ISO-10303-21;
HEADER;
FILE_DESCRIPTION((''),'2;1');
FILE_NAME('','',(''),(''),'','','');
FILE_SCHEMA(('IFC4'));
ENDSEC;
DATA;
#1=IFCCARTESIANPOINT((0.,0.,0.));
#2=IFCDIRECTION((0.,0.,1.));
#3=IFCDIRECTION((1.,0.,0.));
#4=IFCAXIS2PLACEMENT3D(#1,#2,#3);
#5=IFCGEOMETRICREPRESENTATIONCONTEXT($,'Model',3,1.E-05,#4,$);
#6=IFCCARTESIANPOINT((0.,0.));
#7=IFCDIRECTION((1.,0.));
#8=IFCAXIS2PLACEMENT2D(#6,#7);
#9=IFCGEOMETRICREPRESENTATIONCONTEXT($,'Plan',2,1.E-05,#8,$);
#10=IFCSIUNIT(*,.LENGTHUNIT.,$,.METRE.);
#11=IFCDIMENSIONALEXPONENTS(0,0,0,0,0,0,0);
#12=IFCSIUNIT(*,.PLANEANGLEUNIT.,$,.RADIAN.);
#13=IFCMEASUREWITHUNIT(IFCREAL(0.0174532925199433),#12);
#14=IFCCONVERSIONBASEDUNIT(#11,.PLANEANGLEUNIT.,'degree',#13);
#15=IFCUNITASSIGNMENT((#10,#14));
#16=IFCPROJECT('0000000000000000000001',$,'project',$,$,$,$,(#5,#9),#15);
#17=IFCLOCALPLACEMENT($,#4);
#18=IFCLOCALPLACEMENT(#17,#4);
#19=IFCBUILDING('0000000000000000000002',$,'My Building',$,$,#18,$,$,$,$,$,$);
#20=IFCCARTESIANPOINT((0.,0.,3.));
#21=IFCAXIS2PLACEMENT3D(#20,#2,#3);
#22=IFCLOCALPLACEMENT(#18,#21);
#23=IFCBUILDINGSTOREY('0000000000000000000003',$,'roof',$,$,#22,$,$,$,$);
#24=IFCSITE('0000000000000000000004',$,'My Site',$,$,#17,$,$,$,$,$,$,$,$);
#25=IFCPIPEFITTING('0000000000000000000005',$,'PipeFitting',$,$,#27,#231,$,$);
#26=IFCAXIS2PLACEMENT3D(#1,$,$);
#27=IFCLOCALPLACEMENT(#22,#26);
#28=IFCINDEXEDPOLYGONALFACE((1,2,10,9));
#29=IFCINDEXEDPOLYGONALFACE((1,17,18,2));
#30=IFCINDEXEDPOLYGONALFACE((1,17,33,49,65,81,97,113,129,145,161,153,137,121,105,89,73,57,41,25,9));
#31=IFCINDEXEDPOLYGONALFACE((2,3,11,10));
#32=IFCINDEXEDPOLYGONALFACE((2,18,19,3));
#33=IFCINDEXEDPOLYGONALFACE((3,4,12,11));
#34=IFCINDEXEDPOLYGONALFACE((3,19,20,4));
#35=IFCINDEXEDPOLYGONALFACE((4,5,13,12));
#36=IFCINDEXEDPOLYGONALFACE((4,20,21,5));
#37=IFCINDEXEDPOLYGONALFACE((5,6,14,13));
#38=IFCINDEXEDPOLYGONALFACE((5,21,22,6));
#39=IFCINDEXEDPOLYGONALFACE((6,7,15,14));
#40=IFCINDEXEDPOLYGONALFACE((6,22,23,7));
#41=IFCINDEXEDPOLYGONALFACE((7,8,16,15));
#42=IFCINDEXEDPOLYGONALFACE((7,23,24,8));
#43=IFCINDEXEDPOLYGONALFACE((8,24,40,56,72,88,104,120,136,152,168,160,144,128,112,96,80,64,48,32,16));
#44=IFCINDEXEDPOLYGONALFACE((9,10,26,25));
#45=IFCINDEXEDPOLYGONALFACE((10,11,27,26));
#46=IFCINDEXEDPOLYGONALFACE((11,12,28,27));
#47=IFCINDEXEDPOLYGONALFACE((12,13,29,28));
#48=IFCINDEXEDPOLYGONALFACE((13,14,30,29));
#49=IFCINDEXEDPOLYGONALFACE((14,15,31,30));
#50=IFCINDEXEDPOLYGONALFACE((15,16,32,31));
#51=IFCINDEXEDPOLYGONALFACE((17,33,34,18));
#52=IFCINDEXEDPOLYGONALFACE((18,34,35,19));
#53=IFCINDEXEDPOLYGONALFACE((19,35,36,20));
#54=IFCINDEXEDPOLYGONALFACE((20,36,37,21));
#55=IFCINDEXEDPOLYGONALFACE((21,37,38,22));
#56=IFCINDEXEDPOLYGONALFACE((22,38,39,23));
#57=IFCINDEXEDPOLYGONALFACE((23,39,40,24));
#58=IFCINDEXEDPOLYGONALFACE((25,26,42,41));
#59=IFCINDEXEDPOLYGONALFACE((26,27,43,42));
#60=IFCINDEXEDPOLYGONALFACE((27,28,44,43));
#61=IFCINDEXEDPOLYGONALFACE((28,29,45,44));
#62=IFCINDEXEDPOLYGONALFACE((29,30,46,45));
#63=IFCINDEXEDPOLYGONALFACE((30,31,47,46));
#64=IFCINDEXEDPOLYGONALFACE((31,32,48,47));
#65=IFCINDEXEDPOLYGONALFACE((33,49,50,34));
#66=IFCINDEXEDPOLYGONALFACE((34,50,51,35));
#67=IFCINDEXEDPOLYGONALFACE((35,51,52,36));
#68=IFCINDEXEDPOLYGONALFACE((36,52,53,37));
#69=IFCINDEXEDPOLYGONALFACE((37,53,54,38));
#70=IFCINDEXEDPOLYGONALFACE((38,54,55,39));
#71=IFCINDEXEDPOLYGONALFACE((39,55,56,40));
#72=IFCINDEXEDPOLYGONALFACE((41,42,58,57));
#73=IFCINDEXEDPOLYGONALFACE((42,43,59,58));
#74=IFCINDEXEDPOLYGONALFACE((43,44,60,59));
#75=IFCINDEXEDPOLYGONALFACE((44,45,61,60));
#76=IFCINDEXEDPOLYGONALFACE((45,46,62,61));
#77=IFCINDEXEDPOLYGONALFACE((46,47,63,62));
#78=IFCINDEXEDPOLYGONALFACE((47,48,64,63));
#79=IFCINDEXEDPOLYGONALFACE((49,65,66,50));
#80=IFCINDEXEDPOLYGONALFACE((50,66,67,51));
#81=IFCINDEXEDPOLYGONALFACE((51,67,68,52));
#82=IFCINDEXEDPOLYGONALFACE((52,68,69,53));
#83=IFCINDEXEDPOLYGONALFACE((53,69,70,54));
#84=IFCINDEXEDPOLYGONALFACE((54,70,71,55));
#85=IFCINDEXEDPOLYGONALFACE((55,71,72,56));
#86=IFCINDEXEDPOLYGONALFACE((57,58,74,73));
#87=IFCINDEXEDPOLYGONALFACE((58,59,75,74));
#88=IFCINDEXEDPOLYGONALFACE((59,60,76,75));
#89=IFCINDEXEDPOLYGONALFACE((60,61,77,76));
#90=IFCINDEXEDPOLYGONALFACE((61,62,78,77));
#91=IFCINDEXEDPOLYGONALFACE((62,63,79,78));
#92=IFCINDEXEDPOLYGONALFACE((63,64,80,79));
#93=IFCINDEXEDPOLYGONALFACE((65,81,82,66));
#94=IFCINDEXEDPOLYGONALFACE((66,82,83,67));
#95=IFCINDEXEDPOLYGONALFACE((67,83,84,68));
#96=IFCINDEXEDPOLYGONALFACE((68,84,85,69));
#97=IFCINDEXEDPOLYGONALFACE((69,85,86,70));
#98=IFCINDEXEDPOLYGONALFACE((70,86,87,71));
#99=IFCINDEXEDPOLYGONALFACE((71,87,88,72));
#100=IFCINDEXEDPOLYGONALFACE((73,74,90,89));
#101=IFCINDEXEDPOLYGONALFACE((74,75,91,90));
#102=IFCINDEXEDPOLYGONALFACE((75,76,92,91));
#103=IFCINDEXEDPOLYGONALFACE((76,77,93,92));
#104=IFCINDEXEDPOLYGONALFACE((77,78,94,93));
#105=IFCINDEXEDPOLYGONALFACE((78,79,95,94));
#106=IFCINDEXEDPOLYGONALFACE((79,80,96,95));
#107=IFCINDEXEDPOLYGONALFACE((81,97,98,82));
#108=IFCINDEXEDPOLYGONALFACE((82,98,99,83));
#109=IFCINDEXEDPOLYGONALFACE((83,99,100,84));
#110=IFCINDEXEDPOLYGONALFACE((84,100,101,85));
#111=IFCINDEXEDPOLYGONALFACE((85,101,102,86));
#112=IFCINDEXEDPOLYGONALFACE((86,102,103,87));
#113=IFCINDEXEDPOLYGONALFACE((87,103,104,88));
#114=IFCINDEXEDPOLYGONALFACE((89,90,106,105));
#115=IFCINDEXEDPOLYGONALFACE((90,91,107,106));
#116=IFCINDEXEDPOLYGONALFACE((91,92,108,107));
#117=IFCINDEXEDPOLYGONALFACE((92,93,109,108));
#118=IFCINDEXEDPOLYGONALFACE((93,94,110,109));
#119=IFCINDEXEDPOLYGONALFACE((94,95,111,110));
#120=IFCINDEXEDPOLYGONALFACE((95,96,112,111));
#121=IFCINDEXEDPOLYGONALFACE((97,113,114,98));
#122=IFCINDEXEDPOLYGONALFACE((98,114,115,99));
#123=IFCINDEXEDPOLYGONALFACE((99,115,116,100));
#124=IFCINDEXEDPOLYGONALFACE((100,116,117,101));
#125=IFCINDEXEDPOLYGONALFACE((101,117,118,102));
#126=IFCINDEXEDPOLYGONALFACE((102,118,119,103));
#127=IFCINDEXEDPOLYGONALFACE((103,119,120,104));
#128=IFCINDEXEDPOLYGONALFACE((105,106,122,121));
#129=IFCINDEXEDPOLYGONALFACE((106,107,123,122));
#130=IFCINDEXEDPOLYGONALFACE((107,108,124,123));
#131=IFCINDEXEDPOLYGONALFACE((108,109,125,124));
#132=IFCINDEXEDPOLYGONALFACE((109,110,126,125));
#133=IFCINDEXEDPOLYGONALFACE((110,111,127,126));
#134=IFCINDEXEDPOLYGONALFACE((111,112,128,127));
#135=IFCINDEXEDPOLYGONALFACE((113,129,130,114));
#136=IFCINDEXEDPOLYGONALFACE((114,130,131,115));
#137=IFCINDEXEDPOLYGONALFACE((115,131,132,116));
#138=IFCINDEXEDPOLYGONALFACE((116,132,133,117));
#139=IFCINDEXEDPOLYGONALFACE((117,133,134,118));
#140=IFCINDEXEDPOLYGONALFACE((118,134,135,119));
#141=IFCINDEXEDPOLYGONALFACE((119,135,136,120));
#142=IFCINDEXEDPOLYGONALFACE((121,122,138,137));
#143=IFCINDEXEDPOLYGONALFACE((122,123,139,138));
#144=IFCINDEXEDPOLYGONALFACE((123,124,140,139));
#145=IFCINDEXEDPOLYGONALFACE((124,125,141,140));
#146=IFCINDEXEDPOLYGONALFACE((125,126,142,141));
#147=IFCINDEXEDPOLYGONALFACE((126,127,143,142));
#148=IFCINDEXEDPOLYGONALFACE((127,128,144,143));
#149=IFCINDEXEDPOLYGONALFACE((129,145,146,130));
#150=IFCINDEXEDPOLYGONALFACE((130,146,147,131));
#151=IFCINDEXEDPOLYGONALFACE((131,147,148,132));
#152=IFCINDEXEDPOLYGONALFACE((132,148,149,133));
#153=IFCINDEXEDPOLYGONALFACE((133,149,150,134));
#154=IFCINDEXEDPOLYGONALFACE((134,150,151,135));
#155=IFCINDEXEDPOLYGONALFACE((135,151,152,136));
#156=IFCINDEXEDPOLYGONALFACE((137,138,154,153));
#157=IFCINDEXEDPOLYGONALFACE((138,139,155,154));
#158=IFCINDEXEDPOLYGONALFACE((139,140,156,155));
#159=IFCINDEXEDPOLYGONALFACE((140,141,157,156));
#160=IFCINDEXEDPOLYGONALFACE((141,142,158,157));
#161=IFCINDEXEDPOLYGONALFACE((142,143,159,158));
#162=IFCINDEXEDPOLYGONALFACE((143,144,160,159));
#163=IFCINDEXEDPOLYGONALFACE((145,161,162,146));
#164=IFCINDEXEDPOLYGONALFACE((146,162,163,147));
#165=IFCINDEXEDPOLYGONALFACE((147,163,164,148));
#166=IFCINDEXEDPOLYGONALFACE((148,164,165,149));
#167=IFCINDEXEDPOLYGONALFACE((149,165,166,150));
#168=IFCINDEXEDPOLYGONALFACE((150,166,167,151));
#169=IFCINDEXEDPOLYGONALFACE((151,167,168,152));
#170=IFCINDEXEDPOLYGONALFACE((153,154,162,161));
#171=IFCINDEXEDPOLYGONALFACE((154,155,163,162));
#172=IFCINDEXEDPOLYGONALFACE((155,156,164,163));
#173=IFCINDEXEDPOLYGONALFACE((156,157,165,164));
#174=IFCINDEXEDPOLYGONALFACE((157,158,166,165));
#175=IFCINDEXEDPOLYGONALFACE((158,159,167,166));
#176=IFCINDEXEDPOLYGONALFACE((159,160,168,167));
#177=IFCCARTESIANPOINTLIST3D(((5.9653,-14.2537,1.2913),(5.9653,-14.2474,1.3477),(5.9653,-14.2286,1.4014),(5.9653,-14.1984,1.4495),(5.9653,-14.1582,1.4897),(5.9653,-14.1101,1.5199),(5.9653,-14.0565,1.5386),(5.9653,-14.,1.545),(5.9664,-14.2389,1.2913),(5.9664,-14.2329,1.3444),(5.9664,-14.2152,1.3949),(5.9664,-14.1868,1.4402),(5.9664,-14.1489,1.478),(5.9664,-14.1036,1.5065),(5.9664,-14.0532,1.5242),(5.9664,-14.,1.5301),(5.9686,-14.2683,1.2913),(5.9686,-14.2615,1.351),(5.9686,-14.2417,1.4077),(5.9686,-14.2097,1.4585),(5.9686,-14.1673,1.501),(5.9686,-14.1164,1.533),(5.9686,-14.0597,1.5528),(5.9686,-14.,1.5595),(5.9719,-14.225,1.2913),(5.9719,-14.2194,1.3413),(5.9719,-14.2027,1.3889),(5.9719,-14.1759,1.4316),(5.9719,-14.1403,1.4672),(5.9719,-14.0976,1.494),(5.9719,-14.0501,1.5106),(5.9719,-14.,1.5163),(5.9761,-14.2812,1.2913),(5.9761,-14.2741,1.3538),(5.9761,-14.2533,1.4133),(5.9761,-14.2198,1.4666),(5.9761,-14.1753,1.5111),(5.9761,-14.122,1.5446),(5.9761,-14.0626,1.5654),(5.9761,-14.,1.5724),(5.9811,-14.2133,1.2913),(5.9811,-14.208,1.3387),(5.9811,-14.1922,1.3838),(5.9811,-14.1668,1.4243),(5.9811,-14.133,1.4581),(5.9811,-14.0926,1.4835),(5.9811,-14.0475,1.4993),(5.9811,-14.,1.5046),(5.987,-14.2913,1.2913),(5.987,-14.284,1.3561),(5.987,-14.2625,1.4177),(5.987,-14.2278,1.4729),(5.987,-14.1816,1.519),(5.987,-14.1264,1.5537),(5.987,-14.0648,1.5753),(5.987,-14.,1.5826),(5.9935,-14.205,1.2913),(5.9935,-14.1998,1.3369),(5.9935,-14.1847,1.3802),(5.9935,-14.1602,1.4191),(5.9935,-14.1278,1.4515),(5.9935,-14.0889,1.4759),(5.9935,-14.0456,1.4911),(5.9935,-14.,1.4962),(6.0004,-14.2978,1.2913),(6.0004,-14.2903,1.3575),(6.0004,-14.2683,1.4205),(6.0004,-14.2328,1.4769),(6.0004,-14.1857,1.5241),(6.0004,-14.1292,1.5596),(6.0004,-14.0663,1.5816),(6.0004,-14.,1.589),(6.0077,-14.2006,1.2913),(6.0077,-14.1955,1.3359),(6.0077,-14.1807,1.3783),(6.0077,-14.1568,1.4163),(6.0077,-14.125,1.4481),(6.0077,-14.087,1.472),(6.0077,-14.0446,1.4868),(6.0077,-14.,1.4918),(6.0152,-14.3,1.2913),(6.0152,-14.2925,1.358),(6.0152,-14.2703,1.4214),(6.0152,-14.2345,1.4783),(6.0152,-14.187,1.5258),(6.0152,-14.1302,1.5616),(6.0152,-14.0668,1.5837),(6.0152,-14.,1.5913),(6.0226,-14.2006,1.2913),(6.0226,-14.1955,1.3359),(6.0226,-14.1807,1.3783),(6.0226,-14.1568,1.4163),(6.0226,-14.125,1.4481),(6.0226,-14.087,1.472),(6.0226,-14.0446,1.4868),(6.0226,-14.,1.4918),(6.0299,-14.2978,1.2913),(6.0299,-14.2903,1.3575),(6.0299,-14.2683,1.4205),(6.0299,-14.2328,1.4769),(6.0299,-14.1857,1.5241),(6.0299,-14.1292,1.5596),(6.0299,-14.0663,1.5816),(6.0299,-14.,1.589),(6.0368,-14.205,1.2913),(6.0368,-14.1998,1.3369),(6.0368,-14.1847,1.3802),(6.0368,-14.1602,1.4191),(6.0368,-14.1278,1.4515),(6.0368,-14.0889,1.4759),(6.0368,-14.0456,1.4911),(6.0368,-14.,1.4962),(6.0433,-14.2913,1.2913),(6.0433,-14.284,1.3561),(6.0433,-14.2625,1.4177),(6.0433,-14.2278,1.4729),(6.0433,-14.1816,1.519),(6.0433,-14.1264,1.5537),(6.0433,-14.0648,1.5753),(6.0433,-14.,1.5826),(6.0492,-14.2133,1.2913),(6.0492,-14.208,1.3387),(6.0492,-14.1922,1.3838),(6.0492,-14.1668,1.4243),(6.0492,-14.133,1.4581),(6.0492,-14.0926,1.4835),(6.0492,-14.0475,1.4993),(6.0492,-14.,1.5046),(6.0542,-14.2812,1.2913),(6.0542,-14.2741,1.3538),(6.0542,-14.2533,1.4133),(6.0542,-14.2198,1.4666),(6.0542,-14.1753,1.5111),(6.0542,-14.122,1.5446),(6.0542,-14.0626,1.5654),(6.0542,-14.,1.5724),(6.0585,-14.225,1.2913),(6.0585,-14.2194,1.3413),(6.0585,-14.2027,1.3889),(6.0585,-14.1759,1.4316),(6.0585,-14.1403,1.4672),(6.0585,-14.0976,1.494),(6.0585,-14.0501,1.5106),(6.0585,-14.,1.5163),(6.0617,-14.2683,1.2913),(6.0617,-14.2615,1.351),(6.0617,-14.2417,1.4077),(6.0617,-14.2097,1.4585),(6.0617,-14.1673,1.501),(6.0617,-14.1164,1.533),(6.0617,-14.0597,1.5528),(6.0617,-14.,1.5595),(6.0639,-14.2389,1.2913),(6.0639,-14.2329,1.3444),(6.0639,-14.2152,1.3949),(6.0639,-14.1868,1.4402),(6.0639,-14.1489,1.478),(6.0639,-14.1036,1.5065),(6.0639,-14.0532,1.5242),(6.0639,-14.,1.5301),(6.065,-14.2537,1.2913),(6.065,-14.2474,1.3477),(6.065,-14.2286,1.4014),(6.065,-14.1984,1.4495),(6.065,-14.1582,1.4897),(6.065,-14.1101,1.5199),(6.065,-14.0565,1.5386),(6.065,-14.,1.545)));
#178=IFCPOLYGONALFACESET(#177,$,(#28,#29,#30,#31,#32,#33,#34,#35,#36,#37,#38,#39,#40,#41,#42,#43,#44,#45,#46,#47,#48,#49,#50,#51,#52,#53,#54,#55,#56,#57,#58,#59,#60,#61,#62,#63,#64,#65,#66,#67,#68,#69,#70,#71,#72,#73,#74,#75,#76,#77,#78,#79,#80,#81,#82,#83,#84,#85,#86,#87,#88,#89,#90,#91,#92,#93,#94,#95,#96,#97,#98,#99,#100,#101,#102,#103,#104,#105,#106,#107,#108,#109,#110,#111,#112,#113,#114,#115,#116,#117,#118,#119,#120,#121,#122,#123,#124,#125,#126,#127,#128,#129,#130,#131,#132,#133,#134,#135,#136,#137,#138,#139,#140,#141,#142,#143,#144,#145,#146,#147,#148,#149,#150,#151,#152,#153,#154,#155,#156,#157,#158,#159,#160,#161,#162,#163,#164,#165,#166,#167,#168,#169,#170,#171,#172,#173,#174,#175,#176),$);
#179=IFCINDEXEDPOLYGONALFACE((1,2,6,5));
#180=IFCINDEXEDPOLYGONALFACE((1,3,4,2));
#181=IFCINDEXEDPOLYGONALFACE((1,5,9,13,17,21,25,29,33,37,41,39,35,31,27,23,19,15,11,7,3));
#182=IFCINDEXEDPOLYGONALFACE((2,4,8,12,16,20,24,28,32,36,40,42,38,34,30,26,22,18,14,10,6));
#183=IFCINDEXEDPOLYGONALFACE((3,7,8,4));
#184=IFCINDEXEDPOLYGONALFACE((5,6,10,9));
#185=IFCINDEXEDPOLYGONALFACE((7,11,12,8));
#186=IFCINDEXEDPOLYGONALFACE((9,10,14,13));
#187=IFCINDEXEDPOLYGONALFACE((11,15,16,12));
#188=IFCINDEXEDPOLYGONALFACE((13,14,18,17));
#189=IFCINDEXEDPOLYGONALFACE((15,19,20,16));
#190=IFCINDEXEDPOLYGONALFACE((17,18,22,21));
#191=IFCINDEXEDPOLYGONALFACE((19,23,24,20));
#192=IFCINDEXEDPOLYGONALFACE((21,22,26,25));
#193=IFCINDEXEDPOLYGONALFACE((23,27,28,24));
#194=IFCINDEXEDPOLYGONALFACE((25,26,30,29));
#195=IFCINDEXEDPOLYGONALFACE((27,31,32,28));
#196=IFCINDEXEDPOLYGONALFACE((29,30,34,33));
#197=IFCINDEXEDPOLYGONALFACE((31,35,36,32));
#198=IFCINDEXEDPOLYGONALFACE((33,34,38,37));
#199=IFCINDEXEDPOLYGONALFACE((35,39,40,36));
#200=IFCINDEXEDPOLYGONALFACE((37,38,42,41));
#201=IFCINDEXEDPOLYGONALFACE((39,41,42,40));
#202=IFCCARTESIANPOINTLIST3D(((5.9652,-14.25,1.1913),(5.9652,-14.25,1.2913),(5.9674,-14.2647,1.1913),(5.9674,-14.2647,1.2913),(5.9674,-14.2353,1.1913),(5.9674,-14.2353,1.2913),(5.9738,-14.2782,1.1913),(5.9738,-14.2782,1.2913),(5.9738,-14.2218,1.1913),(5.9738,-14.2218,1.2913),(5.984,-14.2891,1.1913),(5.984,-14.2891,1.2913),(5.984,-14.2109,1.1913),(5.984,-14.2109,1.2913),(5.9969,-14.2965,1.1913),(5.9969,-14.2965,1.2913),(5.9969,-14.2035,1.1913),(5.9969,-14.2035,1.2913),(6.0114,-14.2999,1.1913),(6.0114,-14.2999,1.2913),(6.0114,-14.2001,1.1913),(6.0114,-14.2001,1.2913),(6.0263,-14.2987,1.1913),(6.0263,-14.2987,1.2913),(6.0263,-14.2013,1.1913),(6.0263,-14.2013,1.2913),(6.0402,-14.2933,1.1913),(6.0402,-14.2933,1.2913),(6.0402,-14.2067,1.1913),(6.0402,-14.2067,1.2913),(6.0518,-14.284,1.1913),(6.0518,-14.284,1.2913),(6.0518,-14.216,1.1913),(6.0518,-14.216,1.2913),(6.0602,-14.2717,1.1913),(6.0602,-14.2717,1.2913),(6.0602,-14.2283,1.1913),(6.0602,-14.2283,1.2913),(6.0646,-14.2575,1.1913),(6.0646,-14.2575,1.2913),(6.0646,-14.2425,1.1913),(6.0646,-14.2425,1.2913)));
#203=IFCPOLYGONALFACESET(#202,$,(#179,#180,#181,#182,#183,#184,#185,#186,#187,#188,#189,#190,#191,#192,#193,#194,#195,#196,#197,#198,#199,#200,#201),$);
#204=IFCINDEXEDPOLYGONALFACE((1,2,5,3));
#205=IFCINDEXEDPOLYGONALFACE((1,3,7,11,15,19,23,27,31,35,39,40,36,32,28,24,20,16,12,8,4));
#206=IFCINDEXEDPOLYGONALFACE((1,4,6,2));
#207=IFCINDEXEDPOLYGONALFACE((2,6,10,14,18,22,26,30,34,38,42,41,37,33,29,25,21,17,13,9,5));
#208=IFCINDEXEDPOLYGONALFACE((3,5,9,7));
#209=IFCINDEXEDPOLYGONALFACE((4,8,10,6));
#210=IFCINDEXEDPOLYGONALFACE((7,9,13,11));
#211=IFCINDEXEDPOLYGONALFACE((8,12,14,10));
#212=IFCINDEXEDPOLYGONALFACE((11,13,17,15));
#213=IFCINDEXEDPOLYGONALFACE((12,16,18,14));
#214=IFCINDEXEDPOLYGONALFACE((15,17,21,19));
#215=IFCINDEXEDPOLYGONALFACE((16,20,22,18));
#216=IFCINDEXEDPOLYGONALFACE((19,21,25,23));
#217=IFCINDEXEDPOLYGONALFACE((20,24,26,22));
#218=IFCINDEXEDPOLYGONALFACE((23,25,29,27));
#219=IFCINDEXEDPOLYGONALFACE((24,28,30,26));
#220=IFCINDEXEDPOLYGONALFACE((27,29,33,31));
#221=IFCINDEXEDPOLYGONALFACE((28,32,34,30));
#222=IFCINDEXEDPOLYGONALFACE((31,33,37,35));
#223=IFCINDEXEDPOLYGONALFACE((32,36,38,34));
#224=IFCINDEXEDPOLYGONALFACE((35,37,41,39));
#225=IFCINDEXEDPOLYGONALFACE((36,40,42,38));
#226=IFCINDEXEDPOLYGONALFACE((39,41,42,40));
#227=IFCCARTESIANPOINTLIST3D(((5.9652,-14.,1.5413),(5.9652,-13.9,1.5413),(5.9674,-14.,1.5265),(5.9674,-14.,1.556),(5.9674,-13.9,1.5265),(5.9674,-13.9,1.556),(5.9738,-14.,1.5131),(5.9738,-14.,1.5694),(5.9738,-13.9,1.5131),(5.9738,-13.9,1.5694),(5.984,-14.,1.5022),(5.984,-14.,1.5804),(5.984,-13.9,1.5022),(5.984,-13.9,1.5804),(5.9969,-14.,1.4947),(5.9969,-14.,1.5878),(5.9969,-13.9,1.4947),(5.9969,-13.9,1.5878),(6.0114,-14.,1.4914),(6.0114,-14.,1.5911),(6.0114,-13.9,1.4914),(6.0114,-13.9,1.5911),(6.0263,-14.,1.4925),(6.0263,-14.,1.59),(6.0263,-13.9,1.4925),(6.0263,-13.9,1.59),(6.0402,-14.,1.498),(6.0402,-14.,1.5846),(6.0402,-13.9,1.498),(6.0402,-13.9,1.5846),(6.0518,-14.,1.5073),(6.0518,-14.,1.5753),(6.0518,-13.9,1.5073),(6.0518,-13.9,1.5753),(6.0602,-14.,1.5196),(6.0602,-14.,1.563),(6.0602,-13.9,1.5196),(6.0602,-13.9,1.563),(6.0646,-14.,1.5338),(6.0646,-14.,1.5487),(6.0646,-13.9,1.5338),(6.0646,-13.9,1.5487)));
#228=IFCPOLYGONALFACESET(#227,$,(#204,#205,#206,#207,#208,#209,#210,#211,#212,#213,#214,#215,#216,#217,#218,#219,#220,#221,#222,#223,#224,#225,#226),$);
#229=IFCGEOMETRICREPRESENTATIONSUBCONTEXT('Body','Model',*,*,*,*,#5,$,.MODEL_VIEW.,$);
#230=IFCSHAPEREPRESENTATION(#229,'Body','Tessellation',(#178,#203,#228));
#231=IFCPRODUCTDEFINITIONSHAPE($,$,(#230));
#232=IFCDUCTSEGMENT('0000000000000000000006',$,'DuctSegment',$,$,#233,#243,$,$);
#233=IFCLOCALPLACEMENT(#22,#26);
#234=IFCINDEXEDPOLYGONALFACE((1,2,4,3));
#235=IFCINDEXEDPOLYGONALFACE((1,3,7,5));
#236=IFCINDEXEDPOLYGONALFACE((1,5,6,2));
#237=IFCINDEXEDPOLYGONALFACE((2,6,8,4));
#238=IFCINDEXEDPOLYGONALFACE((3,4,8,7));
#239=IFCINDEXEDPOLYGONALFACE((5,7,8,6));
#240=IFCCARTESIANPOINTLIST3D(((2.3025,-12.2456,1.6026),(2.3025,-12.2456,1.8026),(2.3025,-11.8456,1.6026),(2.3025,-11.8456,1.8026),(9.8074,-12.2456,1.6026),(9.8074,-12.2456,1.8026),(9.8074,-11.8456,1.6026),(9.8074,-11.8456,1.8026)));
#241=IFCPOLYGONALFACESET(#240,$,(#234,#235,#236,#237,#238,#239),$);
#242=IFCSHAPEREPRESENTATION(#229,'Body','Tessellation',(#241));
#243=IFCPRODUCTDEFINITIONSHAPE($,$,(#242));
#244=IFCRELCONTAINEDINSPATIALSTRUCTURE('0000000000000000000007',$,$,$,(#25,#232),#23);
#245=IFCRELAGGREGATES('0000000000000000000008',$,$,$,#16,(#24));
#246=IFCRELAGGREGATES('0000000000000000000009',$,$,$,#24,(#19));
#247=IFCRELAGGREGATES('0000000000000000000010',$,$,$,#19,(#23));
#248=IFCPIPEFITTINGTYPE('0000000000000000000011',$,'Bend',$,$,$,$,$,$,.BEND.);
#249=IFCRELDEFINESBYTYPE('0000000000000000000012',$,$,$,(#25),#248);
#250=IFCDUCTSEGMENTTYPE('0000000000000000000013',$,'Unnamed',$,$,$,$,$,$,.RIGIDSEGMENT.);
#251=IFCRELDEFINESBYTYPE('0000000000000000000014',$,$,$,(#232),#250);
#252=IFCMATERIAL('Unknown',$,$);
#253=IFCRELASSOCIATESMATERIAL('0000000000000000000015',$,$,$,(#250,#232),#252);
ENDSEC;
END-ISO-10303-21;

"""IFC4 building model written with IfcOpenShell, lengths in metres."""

from ifc_helpers import new_model, entity, si_unit, converted_unit, frame, origin_with_axes, origin_2d_with_axis, place, context, subcontext, project, spatial, rectangle, circle, extrude, source, transform, mapped, material, material_profile, profile_set, profile_usage, type_object, type_shapes, element, save


model = new_model("IFC4")

# Units and contexts
model_context = context("Model", 3, precision=1e-05, world=origin_with_axes())
plan_context = context("Plan", 2, precision=1e-05, world=origin_2d_with_axis())
body_context_1 = subcontext(model_context, "Body", "Model", "MODEL_VIEW")
ifc_project = project(units=[si_unit("LENGTHUNIT", "METRE"), converted_unit("PLANEANGLEUNIT", "degree", entity("IfcReal", 0.0174532925199433), si_unit("PLANEANGLEUNIT", "RADIAN"), dimensions=[0, 0, 0, 0, 0, 0, 0])], contexts=[model_context, plan_context])

# Site, building, storey
site_placement = place(None, origin_with_axes())
site = spatial("IfcSite", under=ifc_project, at=site_placement, Name="My Site")
building_placement = place(site_placement, origin_with_axes())
building = spatial("IfcBuilding", under=site, at=building_placement, Name="My Building")
storey_placement = place(building_placement, frame((0.0, 0.0, 3.0), z_axis=(0.0, 0.0, 1.0), x_axis=(1.0, 0.0, 0.0)))
storey = spatial("IfcBuildingStorey", under=building, at=storey_placement, Name="roof")

# Shared definitions
ifc_material = material(Name="Unknown")

# Pipe fitting
pipe_fitting_type_1 = type_object("IfcPipeFittingType", Name="Bend", PredefinedType="BEND")
shared_shape_1 = source(origin_with_axes(), body_context_1, "Body", "SolidModel", [
    entity("IfcSweptDiskSolid", entity("IfcIndexedPolyCurve", entity("IfcCartesianPointList3D", [[0.0, 0.0, 0.1], [0.0, -0.0732, 0.2768], [0.0, -0.25, 0.35]]), [entity("IfcArcIndex", [1, 2, 3])]), 0.05),
    extrude(circle(Radius=0.05), origin_with_axes(), (0.0, 0.0, 1.0), 0.1),
    extrude(circle(Radius=0.05), frame((0.0, -0.25, 0.35), z_axis=(0.0, -1.0, 0.0), x_axis=(1.0, 0.0, 0.0)), (0.0, 0.0, 1.0), 0.1),
])
type_shapes(pipe_fitting_type_1, [shared_shape_1])
for number, where, z_axis, x_axis, name in (
    (1, (6.0152, -14.25, 1.1913), (-0.000001, -0.000001, 1.0), (-1.0, 0.0, -0.000001), "PipeFitting"),
):
    element("IfcPipeFitting", number, at=place(storey_placement, frame(where, z_axis=z_axis, x_axis=x_axis)), inside=storey, type_object=pipe_fitting_type_1, Name=name, context=body_context_1, shape_type="MappedRepresentation", body=[
        mapped(shared_shape_1, transform((0.0, 0.0, 0.0), x_axis=(1.0, 0.0, 0.0), y_axis=(0.0, 1.0, 0.0), z_axis=(0.0, 0.0, 1.0), scale=1.0)),
    ])

# Duct segment
ifc_material_profile_1 = material_profile(ifc_material, rectangle(XDim=0.4, YDim=0.2))
ifc_profile_set_1 = profile_set([ifc_material_profile_1])
ifc_profile_usage_1 = profile_usage(ifc_profile_set_1, cardinal=5)
duct_segment_type = type_object("IfcDuctSegmentType", Name="Unnamed", PredefinedType="RIGIDSEGMENT", material=ifc_profile_set_1)
duct_segment_placement = place(storey_placement, frame((2.3025, -12.0456, 1.7026), z_axis=(1.0, 0.0, 0.0), x_axis=(0.0, 1.0, 0.0)))
element("IfcDuctSegment", 2, at=duct_segment_placement, inside=storey, type_object=duct_segment_type, material=ifc_profile_usage_1, Name="DuctSegment", context=body_context_1, shape_type="SweptSolid", body=[
    extrude(rectangle(XDim=0.4, YDim=0.2), origin_with_axes(), (0.0, 0.0, 1.0), 7.505),
])

save(model, "model.ifc")
